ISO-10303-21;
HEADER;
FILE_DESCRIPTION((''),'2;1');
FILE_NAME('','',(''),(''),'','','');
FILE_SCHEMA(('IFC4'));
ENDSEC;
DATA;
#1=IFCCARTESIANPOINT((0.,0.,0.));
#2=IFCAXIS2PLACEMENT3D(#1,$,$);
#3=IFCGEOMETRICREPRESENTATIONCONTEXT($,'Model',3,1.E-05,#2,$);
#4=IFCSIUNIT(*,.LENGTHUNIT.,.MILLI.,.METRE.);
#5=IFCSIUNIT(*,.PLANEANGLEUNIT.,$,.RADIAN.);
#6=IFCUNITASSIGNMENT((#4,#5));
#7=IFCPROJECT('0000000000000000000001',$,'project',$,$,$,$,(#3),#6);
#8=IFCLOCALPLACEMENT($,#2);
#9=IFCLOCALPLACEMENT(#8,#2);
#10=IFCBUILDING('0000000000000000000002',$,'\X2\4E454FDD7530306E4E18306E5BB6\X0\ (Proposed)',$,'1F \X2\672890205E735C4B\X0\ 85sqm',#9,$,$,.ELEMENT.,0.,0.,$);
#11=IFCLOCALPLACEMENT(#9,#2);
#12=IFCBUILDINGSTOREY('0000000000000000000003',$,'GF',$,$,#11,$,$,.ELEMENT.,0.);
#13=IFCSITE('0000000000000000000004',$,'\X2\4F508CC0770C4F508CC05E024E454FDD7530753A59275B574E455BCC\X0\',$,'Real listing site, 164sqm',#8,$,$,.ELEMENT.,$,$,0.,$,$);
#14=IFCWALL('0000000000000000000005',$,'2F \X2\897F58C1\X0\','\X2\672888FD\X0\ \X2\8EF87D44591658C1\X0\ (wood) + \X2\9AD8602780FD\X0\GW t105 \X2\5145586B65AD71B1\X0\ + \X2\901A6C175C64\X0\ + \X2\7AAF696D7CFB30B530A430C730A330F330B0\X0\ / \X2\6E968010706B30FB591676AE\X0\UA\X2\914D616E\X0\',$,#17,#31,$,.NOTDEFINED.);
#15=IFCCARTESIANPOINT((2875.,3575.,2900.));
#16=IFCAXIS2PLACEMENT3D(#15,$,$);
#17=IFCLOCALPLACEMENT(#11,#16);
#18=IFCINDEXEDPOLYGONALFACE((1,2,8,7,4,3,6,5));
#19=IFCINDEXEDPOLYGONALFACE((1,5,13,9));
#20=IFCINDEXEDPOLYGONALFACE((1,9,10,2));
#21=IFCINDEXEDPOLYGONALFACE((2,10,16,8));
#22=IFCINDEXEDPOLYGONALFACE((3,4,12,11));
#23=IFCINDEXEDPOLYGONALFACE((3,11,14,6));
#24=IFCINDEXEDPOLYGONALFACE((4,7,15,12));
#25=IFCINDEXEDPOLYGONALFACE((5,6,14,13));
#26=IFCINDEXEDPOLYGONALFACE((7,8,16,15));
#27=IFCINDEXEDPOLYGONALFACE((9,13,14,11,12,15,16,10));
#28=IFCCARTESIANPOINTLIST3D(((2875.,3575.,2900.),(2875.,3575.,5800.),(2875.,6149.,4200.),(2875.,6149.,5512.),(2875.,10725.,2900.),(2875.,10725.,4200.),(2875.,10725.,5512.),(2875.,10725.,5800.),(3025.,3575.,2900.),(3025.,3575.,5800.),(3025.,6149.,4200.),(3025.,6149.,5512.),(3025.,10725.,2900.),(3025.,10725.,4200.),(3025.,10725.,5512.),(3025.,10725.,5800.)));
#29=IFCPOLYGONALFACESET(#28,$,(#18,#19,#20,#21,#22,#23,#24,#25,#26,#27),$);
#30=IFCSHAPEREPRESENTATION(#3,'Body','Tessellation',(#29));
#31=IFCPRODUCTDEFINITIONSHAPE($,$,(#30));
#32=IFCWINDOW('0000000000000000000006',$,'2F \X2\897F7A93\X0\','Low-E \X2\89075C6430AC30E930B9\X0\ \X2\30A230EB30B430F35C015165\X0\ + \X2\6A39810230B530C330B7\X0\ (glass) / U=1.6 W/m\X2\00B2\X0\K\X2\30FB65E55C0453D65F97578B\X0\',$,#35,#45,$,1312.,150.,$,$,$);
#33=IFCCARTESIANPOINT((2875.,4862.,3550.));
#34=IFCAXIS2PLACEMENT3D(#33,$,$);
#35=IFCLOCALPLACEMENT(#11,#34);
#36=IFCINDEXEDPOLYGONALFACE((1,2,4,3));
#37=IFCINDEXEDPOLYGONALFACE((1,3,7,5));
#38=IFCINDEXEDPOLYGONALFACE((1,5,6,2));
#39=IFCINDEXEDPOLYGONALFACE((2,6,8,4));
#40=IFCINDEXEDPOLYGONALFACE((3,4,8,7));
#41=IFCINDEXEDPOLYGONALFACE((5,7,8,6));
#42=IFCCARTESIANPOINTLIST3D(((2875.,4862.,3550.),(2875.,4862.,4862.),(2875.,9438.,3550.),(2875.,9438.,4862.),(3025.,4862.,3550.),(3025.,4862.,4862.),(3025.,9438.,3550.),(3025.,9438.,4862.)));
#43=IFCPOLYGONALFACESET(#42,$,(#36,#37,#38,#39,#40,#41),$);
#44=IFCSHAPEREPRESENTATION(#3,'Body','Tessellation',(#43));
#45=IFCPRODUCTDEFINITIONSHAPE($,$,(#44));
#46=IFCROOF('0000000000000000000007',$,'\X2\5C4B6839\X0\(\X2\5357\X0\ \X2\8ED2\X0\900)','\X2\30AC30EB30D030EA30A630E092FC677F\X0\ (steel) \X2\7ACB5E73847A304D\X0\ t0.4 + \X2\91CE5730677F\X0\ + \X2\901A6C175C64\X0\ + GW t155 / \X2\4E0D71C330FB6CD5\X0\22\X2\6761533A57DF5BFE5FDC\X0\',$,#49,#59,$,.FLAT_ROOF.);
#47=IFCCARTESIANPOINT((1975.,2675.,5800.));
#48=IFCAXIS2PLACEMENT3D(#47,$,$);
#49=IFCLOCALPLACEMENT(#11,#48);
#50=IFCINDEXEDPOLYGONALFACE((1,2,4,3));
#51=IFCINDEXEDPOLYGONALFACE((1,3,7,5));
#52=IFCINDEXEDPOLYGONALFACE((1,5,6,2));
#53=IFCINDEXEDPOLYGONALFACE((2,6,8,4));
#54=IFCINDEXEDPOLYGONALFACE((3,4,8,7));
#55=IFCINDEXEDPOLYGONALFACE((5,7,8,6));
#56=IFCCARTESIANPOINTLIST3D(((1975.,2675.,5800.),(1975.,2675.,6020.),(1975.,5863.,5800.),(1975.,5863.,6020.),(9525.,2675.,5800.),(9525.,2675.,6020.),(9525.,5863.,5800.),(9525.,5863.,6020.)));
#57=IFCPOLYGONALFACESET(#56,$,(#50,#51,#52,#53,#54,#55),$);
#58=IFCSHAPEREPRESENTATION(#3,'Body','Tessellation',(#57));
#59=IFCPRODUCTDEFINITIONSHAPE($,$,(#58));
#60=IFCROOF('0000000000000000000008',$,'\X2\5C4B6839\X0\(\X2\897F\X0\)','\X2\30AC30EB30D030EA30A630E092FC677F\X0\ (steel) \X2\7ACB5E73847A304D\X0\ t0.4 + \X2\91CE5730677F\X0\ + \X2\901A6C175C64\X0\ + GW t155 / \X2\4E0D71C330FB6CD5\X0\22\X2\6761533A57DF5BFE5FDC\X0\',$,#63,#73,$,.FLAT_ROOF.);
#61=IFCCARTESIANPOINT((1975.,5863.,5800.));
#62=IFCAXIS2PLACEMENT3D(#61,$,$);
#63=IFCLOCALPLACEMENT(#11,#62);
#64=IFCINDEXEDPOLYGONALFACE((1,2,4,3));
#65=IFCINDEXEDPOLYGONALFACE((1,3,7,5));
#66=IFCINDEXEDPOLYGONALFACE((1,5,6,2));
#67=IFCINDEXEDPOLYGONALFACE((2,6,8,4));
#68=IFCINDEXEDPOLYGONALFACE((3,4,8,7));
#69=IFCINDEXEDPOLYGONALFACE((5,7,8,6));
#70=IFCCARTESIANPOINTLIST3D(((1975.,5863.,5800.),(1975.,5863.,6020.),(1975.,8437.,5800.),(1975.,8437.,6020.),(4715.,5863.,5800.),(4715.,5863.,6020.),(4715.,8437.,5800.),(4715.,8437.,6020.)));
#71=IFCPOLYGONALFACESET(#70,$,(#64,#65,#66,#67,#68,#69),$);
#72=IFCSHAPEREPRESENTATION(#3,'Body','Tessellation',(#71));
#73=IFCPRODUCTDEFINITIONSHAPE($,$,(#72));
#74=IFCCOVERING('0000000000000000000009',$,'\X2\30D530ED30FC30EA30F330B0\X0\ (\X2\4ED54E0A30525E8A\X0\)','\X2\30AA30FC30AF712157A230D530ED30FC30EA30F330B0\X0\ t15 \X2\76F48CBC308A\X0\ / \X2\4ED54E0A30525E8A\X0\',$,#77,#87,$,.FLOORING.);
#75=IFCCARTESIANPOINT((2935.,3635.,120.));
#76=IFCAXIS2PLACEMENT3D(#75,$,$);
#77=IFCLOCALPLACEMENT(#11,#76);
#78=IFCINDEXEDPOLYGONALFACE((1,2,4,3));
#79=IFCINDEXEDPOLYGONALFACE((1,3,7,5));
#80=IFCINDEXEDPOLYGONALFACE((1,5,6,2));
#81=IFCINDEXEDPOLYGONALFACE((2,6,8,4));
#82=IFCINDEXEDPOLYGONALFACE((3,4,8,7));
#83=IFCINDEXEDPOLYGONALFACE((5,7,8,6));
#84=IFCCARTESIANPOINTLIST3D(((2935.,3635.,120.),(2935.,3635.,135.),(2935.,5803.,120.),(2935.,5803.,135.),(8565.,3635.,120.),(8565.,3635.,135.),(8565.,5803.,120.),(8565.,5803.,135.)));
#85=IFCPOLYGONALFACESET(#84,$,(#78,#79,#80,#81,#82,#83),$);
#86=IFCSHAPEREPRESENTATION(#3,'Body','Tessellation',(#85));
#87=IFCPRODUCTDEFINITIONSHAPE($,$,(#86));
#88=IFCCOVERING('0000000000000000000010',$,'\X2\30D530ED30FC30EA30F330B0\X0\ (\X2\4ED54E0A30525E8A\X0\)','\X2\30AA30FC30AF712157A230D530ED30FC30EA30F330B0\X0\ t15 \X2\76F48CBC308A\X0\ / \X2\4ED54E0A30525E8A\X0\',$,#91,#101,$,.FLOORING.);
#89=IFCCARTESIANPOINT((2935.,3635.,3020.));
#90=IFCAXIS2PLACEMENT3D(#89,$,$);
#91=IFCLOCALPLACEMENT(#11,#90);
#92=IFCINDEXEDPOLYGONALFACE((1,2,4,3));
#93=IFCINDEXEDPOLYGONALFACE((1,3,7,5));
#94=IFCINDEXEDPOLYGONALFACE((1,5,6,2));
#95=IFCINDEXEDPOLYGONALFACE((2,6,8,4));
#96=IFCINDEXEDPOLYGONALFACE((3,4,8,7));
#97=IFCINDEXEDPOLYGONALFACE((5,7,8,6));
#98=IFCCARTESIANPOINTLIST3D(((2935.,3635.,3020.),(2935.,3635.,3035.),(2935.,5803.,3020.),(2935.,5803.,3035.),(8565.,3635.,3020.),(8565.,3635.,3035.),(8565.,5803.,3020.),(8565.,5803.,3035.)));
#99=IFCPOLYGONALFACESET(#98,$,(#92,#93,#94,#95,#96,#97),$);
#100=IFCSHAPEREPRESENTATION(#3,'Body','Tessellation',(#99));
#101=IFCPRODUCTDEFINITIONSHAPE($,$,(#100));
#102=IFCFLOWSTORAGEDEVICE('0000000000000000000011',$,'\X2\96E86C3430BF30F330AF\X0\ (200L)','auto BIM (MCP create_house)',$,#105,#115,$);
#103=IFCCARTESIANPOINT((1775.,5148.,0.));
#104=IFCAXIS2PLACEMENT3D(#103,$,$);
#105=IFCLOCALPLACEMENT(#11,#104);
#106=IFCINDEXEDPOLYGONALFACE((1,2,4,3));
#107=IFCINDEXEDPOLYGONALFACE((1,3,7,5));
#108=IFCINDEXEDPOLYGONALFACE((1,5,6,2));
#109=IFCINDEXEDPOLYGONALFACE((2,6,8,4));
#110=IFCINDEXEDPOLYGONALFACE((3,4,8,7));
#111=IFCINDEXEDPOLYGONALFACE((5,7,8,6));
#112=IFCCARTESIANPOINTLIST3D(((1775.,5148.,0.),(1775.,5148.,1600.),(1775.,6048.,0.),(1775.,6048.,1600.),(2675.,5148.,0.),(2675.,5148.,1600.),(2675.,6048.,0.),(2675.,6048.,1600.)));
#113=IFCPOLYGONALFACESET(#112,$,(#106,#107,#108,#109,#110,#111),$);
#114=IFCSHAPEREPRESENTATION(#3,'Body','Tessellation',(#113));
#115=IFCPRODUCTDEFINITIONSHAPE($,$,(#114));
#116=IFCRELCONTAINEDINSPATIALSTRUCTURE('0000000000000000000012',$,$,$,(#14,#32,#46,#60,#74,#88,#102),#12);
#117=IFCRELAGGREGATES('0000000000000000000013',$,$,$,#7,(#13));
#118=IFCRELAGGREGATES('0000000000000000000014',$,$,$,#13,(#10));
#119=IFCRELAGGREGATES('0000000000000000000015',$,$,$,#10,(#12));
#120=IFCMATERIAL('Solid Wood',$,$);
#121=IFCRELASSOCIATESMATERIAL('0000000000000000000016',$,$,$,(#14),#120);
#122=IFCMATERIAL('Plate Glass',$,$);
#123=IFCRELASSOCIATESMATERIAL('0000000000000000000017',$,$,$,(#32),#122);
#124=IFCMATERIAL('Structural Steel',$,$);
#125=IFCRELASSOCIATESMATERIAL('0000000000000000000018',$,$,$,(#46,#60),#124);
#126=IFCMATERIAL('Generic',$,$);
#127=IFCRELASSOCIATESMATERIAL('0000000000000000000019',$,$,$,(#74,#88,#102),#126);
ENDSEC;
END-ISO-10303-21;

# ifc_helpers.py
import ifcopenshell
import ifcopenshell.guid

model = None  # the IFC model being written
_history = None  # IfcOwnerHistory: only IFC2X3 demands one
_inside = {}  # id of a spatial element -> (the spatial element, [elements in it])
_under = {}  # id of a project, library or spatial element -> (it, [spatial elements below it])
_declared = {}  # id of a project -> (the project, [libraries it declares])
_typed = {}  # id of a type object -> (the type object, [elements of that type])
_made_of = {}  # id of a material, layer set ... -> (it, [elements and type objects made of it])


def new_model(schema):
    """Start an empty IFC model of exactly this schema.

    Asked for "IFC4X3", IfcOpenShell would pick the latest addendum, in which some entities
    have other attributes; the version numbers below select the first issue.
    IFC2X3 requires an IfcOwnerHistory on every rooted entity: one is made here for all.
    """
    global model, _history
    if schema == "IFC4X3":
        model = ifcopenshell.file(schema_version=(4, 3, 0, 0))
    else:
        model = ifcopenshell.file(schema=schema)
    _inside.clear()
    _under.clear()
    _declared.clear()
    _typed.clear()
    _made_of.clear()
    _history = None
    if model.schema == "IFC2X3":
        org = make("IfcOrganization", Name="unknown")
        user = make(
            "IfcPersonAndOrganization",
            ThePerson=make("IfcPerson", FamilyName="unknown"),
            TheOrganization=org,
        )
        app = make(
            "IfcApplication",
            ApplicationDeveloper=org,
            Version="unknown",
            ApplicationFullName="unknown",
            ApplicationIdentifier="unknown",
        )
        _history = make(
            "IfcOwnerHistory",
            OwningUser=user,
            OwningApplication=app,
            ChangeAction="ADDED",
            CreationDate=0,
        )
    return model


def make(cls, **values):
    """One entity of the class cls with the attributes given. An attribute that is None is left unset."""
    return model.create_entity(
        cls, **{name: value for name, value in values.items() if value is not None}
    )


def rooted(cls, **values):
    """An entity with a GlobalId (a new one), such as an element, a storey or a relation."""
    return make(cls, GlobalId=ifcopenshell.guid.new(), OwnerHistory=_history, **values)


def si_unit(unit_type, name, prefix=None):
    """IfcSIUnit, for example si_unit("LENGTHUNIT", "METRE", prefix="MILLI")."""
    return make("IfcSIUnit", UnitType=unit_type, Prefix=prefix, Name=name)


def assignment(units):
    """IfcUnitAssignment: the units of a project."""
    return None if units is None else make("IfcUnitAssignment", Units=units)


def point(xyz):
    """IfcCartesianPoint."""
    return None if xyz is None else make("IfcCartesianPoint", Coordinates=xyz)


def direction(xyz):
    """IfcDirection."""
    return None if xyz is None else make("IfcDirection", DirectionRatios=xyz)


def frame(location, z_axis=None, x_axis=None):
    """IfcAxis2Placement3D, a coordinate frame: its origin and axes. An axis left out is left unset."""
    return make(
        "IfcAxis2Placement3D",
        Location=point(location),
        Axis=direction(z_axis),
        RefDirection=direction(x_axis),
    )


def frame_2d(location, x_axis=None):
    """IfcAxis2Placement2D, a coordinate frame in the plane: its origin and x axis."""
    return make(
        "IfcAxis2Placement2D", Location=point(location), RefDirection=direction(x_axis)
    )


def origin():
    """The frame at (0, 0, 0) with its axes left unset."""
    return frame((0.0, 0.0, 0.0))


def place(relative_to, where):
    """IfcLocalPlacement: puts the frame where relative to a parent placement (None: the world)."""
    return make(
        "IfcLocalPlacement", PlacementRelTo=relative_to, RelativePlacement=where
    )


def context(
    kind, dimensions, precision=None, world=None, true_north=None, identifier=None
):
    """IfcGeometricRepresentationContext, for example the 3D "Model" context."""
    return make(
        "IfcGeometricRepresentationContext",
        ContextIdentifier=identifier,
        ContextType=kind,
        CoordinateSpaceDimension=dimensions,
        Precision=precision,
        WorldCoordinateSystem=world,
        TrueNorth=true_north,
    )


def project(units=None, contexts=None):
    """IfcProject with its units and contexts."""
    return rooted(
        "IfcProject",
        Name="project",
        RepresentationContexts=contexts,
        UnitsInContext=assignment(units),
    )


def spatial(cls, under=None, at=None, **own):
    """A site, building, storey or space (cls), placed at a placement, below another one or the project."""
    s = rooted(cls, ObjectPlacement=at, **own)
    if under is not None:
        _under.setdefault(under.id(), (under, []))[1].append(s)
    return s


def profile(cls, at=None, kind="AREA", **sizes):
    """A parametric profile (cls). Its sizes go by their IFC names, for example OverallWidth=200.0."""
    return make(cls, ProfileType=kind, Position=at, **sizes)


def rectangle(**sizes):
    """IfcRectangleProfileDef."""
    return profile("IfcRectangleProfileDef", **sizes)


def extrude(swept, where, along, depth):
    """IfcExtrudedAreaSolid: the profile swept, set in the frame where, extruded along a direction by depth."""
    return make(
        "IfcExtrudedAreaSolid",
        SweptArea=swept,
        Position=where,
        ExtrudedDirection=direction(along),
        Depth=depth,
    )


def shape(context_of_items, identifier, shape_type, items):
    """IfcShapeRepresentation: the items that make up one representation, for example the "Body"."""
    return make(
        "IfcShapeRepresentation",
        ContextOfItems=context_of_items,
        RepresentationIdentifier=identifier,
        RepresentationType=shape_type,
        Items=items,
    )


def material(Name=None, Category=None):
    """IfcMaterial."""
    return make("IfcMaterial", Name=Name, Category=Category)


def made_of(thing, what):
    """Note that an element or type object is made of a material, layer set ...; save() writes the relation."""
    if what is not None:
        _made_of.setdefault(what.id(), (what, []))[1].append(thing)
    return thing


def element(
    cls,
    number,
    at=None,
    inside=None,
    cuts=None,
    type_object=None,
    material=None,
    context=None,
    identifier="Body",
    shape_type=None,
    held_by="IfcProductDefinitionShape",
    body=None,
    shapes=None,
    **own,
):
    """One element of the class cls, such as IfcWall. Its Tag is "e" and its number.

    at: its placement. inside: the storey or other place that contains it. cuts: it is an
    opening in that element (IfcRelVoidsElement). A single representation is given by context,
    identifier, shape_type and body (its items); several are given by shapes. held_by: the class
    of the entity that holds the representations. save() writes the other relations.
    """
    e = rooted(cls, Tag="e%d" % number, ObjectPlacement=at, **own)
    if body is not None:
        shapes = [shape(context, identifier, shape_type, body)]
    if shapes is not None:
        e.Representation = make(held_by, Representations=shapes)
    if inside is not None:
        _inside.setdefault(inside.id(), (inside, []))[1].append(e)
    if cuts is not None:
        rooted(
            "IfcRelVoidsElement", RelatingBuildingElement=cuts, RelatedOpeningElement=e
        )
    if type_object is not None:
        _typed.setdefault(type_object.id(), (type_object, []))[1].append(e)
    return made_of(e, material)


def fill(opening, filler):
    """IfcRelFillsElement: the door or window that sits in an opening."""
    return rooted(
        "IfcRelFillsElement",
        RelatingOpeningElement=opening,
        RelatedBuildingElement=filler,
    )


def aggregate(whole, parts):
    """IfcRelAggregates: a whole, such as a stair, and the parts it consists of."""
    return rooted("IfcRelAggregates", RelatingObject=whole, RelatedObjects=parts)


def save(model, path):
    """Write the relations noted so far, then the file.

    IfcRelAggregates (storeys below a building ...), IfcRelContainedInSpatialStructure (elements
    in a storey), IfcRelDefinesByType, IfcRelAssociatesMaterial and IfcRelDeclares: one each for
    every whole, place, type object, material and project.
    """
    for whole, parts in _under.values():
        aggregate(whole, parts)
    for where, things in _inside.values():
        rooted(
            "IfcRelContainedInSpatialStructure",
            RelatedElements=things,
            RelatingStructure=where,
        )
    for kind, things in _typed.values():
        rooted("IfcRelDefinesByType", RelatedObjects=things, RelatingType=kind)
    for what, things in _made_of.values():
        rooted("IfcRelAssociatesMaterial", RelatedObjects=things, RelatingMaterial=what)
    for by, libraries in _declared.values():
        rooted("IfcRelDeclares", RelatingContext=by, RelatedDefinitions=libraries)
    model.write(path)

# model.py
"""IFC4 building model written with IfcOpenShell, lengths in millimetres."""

from ifc_helpers import new_model, si_unit, frame, frame_2d, origin, place, context, project, spatial, rectangle, extrude, material, element, fill, save


model = new_model("IFC4")

# Units and contexts
model_context = context("Model", 3, precision=1e-05, world=origin())
ifc_project = project(units=[si_unit("LENGTHUNIT", "METRE", prefix="MILLI"), si_unit("PLANEANGLEUNIT", "RADIAN")], contexts=[model_context])

# Site, building, storey
site_placement = place(None, origin())
site = spatial("IfcSite", under=ifc_project, at=site_placement, Name="佐賀県佐賀市久保田町大字久富", ObjectType="Real listing site, 164sqm", CompositionType="ELEMENT", RefElevation=0.0)
building_placement = place(site_placement, origin())
building = spatial("IfcBuilding", under=site, at=building_placement, Name="久保田の丘の家 (Proposed)", ObjectType="1F 木造平屋 85sqm", CompositionType="ELEMENT", ElevationOfRefHeight=0.0, ElevationOfTerrain=0.0)
storey_placement = place(building_placement, origin())
storey = spatial("IfcBuildingStorey", under=building, at=storey_placement, Name="GF", CompositionType="ELEMENT", Elevation=0.0)

# Shared definitions
ifc_material_1 = material(Name="Solid Wood")
ifc_material_2 = material(Name="Generic")

# Shared definitions
ifc_material_3 = material(Name="Plate Glass")

# Wall, opening, window
wall_1_placement = place(storey_placement, frame((2875.0, 3575.0, 2900.0)))
wall_1 = element("IfcWall", 1, at=wall_1_placement, inside=storey, material=ifc_material_1, Name="2F 西壁", Description="木製 軸組外壁 (wood) + 高性能GW t105 充填断熱 + 通気層 + 窯業系サイディング / 準耐火・外皮UA配慮", PredefinedType="NOTDEFINED", context=model_context, shape_type="SweptSolid", body=[
    extrude(rectangle(XDim=150.0, YDim=7150.0, at=frame_2d((75.0, 3575.0))), frame((2875.0, 3575.0, 2900.0)), (0.0, 0.0, 1.0), 2900.0),
])
opening_1_placement = place(storey_placement, frame((2875.0, 4862.0, 3550.0)))
opening_1 = element("IfcOpeningElement", 2, at=opening_1_placement, cuts=wall_1, PredefinedType="NOTDEFINED", context=model_context, shape_type="SweptSolid", body=[
    extrude(rectangle(XDim=150.0, YDim=4576.0, at=frame_2d((75.0, 2288.0))), frame((2875.0, 4862.0, 3550.0)), (0.0, 0.0, 1.0), 1312.0),
])
window_1_placement = place(storey_placement, frame((2875.0, 4862.0, 3550.0)))
window_1 = element("IfcWindow", 3, at=window_1_placement, inside=storey, material=ifc_material_3, Name="2F 西窓", Description="Low-E 複層ガラス アルゴン封入 + 樹脂サッシ (glass) / U=1.6 W/m²K・日射取得型", OverallHeight=1312.0, OverallWidth=150.0, context=model_context, shape_type="SweptSolid", body=[
    extrude(rectangle(XDim=150.0, YDim=4576.0, at=frame_2d((75.0, 2288.0))), frame((2875.0, 4862.0, 3550.0)), (0.0, 0.0, 1.0), 1312.0),
])
fill(opening_1, window_1)

# Roofs
ifc_material_4 = material(Name="Structural Steel")
roof_1_placement = place(storey_placement, frame((1975.0, 2675.0, 5800.0)))
element("IfcRoof", 4, at=roof_1_placement, inside=storey, material=ifc_material_4, Name="屋根(南 軒900)", Description="ガルバリウム鋼板 (steel) 立平葺き t0.4 + 野地板 + 通気層 + GW t155 / 不燃・法22条区域対応", PredefinedType="FLAT_ROOF", context=model_context, shape_type="SweptSolid", body=[
    extrude(rectangle(XDim=7550.0, YDim=3188.0, at=frame_2d((3775.0, 1594.0))), frame((1975.0, 2675.0, 5800.0)), (0.0, 0.0, 1.0), 220.0),
])
roof_2_placement = place(storey_placement, frame((1975.0, 5863.0, 5800.0)))
element("IfcRoof", 5, at=roof_2_placement, inside=storey, material=ifc_material_4, Name="屋根(西)", Description="ガルバリウム鋼板 (steel) 立平葺き t0.4 + 野地板 + 通気層 + GW t155 / 不燃・法22条区域対応", PredefinedType="FLAT_ROOF", context=model_context, shape_type="SweptSolid", body=[
    extrude(rectangle(XDim=2740.0, YDim=2574.0, at=frame_2d((1370.0, 1287.0))), frame((1975.0, 5863.0, 5800.0)), (0.0, 0.0, 1.0), 220.0),
])

# Coverings
covering_1_placement = place(storey_placement, frame((2935.0, 3635.0, 120.0)))
element("IfcCovering", 6, at=covering_1_placement, inside=storey, material=ifc_material_2, Name="フローリング (仕上げ床)", Description="オーク無垢フローリング t15 直貼り / 仕上げ床", PredefinedType="FLOORING", context=model_context, shape_type="SweptSolid", body=[
    extrude(rectangle(XDim=5630.0, YDim=2168.0, at=frame_2d((2815.0, 1084.0))), frame((2935.0, 3635.0, 120.0)), (0.0, 0.0, 1.0), 15.0),
])
covering_2_placement = place(storey_placement, frame((2935.0, 3635.0, 3020.0)))
element("IfcCovering", 7, at=covering_2_placement, inside=storey, material=ifc_material_2, Name="フローリング (仕上げ床)", Description="オーク無垢フローリング t15 直貼り / 仕上げ床", PredefinedType="FLOORING", context=model_context, shape_type="SweptSolid", body=[
    extrude(rectangle(XDim=5630.0, YDim=2168.0, at=frame_2d((2815.0, 1084.0))), frame((2935.0, 3635.0, 3020.0)), (0.0, 0.0, 1.0), 15.0),
])

# Flow storage device
flow_storage_device_placement = place(storey_placement, frame((1775.0, 5148.0, 0.0)))
element("IfcFlowStorageDevice", 8, at=flow_storage_device_placement, inside=storey, material=ifc_material_2, Name="雨水タンク (200L)", Description="auto BIM (MCP create_house)", context=model_context, shape_type="SweptSolid", body=[
    extrude(rectangle(XDim=900.0, YDim=900.0, at=frame_2d((450.0, 450.0))), frame((1775.0, 5148.0, 0.0)), (0.0, 0.0, 1.0), 1600.0),
])

save(model, "model.ifc")
